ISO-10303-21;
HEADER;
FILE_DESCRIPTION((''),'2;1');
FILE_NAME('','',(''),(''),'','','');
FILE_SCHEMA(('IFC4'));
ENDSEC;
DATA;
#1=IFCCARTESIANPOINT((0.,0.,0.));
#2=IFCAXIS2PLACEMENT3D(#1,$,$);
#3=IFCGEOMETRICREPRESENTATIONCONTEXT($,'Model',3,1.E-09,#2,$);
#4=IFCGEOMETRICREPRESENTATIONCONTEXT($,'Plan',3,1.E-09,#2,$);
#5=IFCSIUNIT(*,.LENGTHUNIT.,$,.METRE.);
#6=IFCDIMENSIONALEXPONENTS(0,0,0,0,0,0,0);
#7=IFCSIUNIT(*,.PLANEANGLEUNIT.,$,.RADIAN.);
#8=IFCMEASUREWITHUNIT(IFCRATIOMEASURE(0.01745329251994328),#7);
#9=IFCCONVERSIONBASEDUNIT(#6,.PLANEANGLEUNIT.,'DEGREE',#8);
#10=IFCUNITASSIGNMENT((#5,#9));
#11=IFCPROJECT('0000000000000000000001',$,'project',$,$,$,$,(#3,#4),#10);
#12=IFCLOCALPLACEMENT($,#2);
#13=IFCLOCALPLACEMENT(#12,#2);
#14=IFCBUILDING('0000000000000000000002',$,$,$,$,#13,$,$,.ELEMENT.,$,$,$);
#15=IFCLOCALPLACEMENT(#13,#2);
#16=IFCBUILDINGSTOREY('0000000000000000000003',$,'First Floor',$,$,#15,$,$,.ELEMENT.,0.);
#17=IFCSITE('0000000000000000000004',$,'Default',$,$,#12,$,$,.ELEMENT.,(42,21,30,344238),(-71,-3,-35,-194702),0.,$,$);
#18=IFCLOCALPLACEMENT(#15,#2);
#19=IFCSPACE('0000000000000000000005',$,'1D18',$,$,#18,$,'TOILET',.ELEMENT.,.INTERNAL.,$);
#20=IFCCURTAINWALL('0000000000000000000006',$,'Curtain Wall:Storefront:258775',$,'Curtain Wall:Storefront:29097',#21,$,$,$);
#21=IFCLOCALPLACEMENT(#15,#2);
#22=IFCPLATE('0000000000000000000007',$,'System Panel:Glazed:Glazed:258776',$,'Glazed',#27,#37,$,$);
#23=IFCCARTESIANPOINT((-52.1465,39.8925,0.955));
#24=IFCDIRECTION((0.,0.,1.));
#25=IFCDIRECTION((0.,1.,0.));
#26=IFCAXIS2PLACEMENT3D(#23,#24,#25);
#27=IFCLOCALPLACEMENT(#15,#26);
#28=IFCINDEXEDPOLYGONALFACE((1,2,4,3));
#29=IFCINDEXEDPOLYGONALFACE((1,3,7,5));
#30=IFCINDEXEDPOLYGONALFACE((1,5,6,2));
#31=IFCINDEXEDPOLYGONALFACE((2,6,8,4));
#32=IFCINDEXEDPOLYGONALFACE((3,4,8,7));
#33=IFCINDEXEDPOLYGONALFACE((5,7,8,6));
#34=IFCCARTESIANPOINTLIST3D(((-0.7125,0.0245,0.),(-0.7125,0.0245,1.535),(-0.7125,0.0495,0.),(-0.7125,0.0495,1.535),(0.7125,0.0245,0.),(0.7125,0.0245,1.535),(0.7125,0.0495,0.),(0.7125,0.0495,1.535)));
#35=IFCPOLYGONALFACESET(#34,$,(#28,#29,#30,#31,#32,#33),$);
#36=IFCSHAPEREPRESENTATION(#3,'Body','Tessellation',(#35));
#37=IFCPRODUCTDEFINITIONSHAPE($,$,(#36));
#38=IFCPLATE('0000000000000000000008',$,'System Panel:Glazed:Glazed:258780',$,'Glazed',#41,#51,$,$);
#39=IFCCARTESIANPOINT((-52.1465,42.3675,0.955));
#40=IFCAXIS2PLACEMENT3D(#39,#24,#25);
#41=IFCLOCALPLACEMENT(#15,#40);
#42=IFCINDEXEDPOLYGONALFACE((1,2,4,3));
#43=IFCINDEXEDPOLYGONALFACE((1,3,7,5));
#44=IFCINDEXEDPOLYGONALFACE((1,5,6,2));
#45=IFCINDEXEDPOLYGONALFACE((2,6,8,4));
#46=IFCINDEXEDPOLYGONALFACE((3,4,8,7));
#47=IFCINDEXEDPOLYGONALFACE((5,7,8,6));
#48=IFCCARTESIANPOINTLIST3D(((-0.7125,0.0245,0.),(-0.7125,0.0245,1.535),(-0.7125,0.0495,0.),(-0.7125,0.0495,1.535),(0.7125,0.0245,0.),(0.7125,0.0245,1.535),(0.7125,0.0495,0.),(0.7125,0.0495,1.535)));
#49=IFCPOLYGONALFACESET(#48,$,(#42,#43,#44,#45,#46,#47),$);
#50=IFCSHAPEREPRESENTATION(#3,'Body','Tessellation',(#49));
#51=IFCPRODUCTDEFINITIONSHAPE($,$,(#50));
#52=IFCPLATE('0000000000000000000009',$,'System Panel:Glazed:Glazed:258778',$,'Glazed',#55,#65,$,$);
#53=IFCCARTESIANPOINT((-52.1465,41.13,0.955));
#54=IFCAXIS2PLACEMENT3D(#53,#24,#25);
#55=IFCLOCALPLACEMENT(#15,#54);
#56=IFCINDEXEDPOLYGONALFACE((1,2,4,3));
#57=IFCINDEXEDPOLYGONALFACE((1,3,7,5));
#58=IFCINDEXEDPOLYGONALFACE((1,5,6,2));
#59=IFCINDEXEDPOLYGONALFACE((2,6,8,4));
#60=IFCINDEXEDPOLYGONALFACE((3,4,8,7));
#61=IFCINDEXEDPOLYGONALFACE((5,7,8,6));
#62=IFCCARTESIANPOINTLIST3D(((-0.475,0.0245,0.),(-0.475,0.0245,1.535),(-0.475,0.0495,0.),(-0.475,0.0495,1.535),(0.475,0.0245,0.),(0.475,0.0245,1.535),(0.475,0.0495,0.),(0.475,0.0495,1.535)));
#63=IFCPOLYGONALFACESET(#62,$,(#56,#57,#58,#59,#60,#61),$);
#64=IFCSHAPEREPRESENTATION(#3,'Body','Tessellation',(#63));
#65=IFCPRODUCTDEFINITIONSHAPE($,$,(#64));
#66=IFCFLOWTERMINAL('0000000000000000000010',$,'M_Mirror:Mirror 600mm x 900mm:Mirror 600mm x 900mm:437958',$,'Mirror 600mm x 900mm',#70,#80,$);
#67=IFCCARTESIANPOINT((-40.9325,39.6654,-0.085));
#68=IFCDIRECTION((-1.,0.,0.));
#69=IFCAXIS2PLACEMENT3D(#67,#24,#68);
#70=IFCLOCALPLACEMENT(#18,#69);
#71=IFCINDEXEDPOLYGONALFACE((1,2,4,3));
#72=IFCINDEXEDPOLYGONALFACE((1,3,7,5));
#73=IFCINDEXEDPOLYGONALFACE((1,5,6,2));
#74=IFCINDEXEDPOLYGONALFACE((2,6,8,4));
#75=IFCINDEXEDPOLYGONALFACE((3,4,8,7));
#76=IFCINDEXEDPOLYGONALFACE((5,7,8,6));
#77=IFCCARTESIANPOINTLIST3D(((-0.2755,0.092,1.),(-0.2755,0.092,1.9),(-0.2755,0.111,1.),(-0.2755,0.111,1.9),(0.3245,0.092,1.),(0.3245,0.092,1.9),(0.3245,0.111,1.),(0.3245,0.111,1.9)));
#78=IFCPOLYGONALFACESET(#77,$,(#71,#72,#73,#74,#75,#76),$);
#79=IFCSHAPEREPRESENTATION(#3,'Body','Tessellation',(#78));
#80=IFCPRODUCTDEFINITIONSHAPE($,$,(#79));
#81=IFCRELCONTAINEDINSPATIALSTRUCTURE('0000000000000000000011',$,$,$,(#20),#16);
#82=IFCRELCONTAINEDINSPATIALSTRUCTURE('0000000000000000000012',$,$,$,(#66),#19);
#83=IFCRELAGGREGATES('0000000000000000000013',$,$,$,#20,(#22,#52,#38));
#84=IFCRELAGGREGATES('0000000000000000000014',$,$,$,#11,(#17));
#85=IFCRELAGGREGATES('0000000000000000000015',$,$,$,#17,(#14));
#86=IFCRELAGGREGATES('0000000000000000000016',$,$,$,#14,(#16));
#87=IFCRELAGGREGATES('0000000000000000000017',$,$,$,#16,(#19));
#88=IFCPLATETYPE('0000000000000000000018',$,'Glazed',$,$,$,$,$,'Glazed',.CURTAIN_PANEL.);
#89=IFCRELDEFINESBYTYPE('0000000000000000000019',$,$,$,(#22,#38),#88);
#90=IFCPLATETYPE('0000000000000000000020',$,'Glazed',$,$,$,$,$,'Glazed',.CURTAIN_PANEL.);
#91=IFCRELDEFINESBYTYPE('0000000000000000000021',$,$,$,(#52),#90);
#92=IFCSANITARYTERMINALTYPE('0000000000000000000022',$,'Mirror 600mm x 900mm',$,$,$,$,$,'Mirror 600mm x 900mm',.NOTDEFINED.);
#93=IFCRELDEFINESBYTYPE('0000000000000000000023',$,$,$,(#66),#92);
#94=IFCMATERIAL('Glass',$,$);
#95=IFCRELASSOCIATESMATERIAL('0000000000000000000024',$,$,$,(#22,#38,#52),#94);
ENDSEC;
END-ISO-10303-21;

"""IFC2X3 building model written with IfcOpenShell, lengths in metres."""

from ifc_helpers import new_model, entity, si_unit, converted_unit, frame, origin, origin_2d_with_axis, place, context, project, spatial, rectangle, extrude, source, transform, mapped, material, type_object, type_shapes, element, aggregate, save


model = new_model("IFC2X3")

# Units and contexts
model_context = context("Model", 3, precision=1e-09, world=origin())
plan_context = context("Plan", 3, precision=1e-09, world=origin())
ifc_project = project(units=[si_unit("LENGTHUNIT", "METRE"), converted_unit("PLANEANGLEUNIT", "DEGREE", entity("IfcRatioMeasure", 0.01745329251994328), si_unit("PLANEANGLEUNIT", "RADIAN"), dimensions=[0, 0, 0, 0, 0, 0, 0])], contexts=[model_context, plan_context])

# Site, building, storey
site_placement = place(None, origin())
site = spatial("IfcSite", under=ifc_project, at=site_placement, Name="Default", CompositionType="ELEMENT", RefLatitude=(42, 21, 30, 344238), RefLongitude=(-71, -3, -35, -194702), RefElevation=0.0)
building_placement = place(site_placement, origin())
building = spatial("IfcBuilding", under=site, at=building_placement, CompositionType="ELEMENT")
storey_placement = place(building_placement, origin())
storey = spatial("IfcBuildingStorey", under=building, at=storey_placement, Name="First Floor", CompositionType="ELEMENT", Elevation=0.0)

# Curtain wall, plates
curtain_wall_placement = place(storey_placement, origin())
curtain_wall = element("IfcCurtainWall", 1, at=curtain_wall_placement, inside=storey, Name="Curtain Wall:Storefront:258775", ObjectType="Curtain Wall:Storefront:29097")
ifc_material_1 = material(Name="Glass")
plate_type_1 = type_object("IfcPlateType", Name="Glazed", ElementType="Glazed", PredefinedType="CURTAIN_PANEL")
shared_shape_1 = source(origin(), model_context, "Body", "SweptSolid", [
    extrude(rectangle(XDim=0.025, YDim=1.425, at=origin_2d_with_axis()), frame((0.0, 0.037, 0.0), z_axis=(0.0, 0.0, 1.0), x_axis=(0.0, 1.0, 0.0)), (0.0, 0.0, 1.0), 1.535),
])
type_shapes(plate_type_1, [shared_shape_1])
plate_1_placement = place(storey_placement, frame((-52.1465, 39.8925, 0.955), z_axis=(0.0, 0.0, 1.0), x_axis=(0.0, 1.0, 0.0)))
plate_1 = element("IfcPlate", 2, at=plate_1_placement, type_object=plate_type_1, material=ifc_material_1, Name="System Panel:Glazed:Glazed:258776", ObjectType="Glazed", context=model_context, shape_type="MappedRepresentation", body=[
    mapped(shared_shape_1, transform((0.0, 0.0, 0.0), scale=1.0)),
])
plate_2_placement = place(storey_placement, frame((-52.1465, 42.3675, 0.955), z_axis=(0.0, 0.0, 1.0), x_axis=(0.0, 1.0, 0.0)))
plate_2 = element("IfcPlate", 3, at=plate_2_placement, type_object=plate_type_1, material=ifc_material_1, Name="System Panel:Glazed:Glazed:258780", ObjectType="Glazed", context=model_context, shape_type="MappedRepresentation", body=[
    mapped(shared_shape_1, transform((0.0, 0.0, 0.0), scale=1.0)),
])
plate_type_2 = type_object("IfcPlateType", Name="Glazed", ElementType="Glazed", PredefinedType="CURTAIN_PANEL")
shared_shape_2 = source(origin(), model_context, "Body", "SweptSolid", [
    extrude(rectangle(XDim=0.025, YDim=0.95, at=origin_2d_with_axis()), frame((0.0, 0.037, 0.0), z_axis=(0.0, 0.0, 1.0), x_axis=(0.0, 1.0, 0.0)), (0.0, 0.0, 1.0), 1.535),
])
type_shapes(plate_type_2, [shared_shape_2])
plate_3_placement = place(storey_placement, frame((-52.1465, 41.13, 0.955), z_axis=(0.0, 0.0, 1.0), x_axis=(0.0, 1.0, 0.0)))
plate_3 = element("IfcPlate", 4, at=plate_3_placement, type_object=plate_type_2, material=ifc_material_1, Name="System Panel:Glazed:Glazed:258778", ObjectType="Glazed", context=model_context, shape_type="MappedRepresentation", body=[
    mapped(shared_shape_2, transform((0.0, 0.0, 0.0), scale=1.0)),
])
aggregate(curtain_wall, [plate_1, plate_3, plate_2])

# Shared definitions
space_placement = place(storey_placement, origin())
space = spatial("IfcSpace", under=storey, at=space_placement, Name="1D18", LongName="TOILET", CompositionType="ELEMENT", InteriorOrExteriorSpace="INTERNAL")

# Flow terminal
sanitary_terminal_type = type_object("IfcSanitaryTerminalType", Name="Mirror 600mm x 900mm", ElementType="Mirror 600mm x 900mm", PredefinedType="NOTDEFINED")
shared_shape_3 = source(origin(), model_context, "Body", "SweptSolid", [
    extrude(rectangle(XDim=0.0191, YDim=0.6, at=origin_2d_with_axis()), frame((0.0245, 0.1015, 1.0), z_axis=(0.0, 0.0, 1.0), x_axis=(0.0, -1.0, 0.0)), (0.0, 0.0, 1.0), 0.9),
])
type_shapes(sanitary_terminal_type, [shared_shape_3])
flow_terminal_placement = place(space_placement, frame((-40.9325, 39.6654, -0.085), z_axis=(0.0, 0.0, 1.0), x_axis=(-1.0, 0.0, 0.0)))
element("IfcFlowTerminal", 5, at=flow_terminal_placement, inside=space, type_object=sanitary_terminal_type, Name="M_Mirror:Mirror 600mm x 900mm:Mirror 600mm x 900mm:437958", ObjectType="Mirror 600mm x 900mm", context=model_context, shape_type="MappedRepresentation", body=[
    mapped(shared_shape_3, transform((0.0, 0.0, 0.0), scale=1.0)),
])

save(model, "model.ifc")
